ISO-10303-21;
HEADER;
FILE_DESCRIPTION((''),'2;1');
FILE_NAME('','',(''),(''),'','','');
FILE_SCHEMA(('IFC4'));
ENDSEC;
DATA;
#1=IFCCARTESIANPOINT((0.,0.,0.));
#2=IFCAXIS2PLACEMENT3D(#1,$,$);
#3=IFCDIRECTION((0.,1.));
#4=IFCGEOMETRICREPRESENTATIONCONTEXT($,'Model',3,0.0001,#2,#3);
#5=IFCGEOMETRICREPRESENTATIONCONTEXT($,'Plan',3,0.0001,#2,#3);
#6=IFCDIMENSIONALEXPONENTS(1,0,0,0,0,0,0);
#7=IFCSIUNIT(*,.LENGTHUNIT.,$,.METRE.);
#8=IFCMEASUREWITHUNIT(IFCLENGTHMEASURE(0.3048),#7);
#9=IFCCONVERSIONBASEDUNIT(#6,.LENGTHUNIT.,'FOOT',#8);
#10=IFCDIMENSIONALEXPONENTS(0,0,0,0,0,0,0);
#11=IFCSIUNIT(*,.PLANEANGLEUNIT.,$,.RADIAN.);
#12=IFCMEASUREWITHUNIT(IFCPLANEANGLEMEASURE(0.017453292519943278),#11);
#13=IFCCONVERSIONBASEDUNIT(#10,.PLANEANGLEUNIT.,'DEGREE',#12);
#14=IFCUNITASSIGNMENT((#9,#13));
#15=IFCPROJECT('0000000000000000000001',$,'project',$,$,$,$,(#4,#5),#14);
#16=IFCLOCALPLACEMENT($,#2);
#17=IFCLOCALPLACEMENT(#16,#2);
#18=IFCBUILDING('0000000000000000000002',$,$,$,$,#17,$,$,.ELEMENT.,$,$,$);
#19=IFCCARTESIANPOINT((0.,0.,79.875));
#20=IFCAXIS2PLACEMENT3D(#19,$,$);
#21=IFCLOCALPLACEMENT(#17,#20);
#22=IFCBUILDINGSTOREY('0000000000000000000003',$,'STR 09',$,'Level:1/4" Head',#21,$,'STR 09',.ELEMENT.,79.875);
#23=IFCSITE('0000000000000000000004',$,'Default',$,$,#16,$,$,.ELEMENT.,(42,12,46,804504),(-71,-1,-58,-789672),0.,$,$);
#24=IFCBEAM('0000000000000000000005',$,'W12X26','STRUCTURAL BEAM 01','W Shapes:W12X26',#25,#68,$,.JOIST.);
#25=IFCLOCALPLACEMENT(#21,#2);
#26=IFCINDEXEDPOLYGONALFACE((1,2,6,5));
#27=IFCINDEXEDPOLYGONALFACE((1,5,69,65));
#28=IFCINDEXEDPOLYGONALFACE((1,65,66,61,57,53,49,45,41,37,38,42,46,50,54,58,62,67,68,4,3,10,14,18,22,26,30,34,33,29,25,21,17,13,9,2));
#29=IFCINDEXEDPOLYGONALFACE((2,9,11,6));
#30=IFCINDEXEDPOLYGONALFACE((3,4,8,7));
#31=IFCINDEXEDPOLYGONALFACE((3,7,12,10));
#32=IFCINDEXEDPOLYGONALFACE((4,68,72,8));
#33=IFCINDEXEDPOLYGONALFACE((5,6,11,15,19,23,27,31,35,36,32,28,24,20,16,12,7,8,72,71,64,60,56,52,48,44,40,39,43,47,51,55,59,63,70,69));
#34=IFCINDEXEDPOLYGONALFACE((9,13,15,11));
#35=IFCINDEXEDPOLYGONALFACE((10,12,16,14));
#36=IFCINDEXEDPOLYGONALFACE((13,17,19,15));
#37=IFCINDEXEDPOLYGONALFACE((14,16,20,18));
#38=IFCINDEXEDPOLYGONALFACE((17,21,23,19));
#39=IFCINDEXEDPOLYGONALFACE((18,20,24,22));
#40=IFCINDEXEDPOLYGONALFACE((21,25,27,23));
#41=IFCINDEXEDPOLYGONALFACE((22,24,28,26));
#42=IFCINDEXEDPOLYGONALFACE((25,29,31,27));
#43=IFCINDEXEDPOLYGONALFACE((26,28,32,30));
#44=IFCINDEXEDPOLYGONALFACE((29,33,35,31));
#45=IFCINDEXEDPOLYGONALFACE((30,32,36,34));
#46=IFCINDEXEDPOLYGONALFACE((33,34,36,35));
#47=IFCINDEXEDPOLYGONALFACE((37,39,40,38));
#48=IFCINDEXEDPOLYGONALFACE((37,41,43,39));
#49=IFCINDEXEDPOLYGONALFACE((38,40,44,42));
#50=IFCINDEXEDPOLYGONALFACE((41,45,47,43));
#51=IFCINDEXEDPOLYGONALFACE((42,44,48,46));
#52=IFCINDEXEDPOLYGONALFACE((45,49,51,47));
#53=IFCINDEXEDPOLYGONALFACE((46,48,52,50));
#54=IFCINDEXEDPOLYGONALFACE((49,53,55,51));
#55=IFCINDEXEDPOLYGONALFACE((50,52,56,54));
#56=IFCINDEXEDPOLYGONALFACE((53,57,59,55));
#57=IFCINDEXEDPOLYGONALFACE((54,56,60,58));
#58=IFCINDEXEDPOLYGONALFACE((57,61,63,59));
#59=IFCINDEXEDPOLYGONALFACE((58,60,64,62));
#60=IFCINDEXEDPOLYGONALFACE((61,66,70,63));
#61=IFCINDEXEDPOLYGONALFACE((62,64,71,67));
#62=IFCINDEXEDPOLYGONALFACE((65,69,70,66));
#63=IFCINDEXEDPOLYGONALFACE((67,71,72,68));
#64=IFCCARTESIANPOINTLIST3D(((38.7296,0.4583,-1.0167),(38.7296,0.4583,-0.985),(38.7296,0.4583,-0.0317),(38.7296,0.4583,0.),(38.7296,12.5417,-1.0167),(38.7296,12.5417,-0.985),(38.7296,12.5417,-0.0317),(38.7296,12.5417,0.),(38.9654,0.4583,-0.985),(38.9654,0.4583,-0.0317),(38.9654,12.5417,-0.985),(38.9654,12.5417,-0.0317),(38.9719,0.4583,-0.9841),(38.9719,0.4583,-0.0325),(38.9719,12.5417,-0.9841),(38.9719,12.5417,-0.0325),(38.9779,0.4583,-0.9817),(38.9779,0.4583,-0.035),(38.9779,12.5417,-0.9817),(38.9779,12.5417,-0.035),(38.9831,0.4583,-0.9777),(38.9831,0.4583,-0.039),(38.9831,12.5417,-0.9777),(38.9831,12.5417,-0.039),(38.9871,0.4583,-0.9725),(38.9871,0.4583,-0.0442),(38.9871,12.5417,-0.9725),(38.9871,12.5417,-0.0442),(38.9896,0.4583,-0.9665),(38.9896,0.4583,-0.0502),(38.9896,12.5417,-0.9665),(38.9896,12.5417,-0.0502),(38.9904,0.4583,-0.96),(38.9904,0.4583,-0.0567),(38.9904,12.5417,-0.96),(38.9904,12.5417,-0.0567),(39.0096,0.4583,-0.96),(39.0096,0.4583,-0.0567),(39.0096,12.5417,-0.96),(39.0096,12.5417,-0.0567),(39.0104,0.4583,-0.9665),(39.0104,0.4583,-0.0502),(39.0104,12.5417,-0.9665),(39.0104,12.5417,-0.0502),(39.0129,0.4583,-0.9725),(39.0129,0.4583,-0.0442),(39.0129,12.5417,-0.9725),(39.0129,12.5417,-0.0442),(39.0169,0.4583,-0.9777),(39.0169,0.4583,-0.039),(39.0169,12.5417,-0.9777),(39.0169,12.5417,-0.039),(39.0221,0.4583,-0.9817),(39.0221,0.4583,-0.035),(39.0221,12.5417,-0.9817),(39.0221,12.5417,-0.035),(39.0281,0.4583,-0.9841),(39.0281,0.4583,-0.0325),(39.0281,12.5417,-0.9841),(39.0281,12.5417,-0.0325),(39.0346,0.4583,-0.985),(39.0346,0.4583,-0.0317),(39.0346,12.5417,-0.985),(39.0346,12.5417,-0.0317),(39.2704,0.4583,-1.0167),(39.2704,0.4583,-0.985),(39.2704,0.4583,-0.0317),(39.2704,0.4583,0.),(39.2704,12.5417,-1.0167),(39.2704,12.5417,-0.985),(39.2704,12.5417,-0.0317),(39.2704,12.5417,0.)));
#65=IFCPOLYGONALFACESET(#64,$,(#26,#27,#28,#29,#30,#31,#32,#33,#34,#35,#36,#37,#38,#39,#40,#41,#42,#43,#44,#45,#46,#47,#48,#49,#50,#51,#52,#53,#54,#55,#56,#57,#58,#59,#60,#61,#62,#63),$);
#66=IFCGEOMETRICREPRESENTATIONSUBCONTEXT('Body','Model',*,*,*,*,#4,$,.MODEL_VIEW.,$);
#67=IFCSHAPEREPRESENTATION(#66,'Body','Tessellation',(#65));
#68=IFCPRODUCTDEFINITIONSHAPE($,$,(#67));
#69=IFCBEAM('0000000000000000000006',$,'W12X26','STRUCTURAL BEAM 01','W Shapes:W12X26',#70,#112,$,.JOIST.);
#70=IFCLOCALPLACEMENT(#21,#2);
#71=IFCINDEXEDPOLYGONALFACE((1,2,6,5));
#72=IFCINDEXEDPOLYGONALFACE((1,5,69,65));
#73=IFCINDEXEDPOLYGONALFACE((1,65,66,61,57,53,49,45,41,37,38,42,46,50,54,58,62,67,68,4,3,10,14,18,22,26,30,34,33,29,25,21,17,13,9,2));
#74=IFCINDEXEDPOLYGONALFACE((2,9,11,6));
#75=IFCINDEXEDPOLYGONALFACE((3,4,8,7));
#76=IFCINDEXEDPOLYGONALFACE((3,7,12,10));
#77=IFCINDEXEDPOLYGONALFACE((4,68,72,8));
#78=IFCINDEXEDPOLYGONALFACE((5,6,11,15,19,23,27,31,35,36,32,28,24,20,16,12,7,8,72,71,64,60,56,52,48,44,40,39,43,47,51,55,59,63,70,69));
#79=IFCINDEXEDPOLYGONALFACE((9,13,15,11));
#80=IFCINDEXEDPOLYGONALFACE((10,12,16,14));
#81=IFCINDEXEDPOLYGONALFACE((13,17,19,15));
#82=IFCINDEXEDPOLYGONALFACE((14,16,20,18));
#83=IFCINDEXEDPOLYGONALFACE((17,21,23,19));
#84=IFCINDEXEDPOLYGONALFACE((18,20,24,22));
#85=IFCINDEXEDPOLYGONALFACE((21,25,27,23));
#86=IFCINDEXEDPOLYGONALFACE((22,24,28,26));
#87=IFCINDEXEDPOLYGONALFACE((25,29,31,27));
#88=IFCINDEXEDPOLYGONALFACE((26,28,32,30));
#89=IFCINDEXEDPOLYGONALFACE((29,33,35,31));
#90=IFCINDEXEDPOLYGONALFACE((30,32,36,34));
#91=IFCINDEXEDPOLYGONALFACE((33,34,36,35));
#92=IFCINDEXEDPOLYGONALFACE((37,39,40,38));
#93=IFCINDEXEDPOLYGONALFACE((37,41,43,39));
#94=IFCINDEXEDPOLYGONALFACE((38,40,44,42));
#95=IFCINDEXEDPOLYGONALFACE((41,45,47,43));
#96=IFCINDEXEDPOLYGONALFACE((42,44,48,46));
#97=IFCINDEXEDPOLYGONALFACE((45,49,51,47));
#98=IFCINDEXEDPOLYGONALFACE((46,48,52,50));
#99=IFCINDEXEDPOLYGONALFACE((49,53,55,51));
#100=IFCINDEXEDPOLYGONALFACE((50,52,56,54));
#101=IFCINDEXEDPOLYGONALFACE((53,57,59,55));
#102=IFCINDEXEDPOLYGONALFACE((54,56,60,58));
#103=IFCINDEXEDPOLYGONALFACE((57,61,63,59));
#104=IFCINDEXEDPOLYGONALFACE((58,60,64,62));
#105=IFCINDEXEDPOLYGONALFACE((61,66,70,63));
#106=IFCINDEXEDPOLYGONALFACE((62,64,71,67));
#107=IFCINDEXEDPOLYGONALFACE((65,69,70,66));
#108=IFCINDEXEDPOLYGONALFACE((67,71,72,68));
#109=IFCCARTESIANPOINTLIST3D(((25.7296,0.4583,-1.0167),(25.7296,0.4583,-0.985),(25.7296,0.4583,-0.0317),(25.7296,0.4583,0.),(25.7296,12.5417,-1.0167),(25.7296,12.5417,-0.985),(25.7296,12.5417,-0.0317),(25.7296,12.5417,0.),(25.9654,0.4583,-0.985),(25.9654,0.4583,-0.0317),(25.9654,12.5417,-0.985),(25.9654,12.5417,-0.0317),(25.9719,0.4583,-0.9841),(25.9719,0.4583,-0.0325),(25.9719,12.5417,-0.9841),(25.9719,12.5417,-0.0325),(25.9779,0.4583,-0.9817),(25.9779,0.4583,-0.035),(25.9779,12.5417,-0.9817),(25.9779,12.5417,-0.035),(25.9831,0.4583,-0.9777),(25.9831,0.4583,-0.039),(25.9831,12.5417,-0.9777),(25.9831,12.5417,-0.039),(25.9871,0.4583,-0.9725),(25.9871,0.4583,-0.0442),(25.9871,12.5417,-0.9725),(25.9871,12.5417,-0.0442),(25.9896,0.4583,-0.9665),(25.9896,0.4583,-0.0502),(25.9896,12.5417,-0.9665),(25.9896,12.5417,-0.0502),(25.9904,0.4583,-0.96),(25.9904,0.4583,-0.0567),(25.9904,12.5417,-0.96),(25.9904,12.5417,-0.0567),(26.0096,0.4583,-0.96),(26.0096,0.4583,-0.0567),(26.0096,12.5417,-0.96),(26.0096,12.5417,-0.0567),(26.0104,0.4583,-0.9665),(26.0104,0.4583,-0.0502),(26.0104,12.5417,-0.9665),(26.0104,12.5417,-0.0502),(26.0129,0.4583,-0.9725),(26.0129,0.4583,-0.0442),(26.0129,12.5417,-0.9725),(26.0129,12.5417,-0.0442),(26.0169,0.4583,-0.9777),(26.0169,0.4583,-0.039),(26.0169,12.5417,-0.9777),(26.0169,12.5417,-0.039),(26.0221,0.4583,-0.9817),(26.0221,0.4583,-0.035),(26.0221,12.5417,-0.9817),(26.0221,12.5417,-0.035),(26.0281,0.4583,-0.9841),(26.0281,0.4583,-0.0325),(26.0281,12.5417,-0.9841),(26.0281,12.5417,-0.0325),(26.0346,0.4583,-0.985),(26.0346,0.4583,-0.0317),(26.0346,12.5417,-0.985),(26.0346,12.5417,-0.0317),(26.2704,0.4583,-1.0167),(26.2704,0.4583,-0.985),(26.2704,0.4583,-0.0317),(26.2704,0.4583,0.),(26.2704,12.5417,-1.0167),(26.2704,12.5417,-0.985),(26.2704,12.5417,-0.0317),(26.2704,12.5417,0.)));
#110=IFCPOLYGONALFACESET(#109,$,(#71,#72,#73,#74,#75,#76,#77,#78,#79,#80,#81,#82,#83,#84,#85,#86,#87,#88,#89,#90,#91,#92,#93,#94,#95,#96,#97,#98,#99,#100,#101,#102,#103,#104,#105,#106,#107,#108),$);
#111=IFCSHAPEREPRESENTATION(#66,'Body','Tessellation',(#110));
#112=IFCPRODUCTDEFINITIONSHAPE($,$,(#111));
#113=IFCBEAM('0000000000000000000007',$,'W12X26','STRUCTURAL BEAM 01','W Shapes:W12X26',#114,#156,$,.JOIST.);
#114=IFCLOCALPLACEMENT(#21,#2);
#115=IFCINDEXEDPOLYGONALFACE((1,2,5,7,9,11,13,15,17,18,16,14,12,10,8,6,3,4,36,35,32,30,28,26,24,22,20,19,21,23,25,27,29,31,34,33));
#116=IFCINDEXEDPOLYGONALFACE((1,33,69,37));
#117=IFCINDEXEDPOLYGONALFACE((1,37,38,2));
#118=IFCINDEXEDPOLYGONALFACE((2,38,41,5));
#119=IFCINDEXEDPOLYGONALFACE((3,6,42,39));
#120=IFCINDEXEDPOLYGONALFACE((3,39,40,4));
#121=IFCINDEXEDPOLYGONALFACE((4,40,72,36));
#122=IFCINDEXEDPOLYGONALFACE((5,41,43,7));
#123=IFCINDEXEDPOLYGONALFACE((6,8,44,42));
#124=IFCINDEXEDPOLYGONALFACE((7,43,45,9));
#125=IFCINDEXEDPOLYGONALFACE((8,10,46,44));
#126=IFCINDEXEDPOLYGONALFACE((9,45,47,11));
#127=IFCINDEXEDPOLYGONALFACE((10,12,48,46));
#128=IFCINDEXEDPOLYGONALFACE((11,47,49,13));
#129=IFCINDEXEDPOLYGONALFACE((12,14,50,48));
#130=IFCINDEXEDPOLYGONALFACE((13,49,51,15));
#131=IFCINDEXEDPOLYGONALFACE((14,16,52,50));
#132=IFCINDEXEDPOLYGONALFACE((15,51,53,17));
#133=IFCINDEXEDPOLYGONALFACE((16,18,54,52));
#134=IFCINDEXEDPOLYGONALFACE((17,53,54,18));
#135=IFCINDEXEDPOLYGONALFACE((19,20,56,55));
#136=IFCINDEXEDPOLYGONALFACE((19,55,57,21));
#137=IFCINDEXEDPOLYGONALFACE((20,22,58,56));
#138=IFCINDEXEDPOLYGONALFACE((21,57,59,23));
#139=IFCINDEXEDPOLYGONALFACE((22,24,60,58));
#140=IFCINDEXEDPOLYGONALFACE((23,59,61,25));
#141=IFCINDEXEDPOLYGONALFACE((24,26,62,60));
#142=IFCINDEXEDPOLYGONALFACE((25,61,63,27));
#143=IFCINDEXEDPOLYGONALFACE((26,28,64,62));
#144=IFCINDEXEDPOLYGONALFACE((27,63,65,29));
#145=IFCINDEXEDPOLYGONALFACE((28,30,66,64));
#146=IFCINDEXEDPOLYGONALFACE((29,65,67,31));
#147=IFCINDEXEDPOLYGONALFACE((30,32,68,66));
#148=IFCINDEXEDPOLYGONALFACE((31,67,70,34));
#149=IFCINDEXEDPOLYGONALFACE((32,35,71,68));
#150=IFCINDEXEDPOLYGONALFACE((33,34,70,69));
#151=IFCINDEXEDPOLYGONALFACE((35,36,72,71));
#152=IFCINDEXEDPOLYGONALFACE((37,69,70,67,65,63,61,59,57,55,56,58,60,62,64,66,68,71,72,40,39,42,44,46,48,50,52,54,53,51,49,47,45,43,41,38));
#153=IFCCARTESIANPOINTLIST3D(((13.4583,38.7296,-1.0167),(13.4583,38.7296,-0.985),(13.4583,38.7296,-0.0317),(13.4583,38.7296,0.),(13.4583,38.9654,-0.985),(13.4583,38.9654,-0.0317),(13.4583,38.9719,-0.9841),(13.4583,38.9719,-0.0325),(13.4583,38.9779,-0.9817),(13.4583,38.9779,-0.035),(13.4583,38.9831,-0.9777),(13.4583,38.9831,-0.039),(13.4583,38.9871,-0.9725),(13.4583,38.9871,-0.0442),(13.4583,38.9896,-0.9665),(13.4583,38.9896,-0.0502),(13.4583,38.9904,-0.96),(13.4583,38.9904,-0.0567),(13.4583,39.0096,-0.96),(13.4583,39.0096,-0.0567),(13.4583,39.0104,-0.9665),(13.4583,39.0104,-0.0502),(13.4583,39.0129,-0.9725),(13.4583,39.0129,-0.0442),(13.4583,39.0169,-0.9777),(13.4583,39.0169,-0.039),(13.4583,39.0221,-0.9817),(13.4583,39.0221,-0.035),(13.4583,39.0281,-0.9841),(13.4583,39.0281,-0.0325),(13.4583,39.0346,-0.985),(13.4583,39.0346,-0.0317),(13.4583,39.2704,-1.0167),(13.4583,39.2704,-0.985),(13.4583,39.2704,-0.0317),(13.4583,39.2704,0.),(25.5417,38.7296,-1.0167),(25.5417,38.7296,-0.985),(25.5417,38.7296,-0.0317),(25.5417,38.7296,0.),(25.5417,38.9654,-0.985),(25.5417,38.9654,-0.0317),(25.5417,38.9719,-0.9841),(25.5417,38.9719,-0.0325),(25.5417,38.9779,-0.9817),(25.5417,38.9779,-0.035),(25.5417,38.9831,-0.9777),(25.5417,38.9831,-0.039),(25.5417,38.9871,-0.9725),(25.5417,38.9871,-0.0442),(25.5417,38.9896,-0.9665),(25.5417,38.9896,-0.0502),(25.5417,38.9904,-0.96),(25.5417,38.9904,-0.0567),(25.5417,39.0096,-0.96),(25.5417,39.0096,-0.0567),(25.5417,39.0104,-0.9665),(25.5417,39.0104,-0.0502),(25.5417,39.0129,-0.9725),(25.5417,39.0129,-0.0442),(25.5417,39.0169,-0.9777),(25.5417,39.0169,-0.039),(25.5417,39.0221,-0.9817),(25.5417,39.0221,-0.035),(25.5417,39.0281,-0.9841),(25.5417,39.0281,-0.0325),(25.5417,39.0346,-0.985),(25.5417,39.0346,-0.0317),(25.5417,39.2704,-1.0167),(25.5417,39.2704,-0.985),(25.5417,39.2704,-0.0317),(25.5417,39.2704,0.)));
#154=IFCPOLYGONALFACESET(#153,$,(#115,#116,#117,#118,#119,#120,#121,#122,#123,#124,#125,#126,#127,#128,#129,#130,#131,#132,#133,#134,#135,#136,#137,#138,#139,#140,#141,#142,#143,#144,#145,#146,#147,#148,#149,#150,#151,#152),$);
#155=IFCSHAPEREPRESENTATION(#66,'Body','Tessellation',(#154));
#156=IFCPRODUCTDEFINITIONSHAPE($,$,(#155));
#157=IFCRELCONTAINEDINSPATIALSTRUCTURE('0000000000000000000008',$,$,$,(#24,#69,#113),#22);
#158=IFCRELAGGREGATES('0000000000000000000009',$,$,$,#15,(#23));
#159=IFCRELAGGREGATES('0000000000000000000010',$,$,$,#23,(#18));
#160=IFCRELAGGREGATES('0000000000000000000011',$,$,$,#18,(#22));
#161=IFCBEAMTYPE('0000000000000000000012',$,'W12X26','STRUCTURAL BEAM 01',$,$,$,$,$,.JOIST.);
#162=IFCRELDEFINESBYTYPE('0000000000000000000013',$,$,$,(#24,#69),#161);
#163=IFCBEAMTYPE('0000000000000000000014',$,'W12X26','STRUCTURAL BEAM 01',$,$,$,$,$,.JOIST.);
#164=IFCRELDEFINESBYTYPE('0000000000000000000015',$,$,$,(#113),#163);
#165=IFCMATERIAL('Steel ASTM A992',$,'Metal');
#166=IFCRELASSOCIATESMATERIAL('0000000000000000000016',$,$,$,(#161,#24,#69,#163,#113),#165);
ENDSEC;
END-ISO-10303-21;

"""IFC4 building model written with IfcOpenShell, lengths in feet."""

from ifc_helpers import new_model, entity, si_unit, converted_unit, direction, frame, origin, place, context, subcontext, project, spatial, line, arc, indexed_curve, outline, extrude, source, transform, mapped, material, type_object, type_shapes, element, save


model = new_model("IFC4")

# Units and contexts
model_context = context("Model", 3, precision=0.0001, world=origin(), true_north=direction((0.0, 1.0)))
plan_context = context("Plan", 3, precision=0.0001, world=origin(), true_north=direction((0.0, 1.0)))
body_context = subcontext(model_context, "Body", "Model", "MODEL_VIEW")
ifc_project = project(units=[converted_unit("LENGTHUNIT", "FOOT", entity("IfcLengthMeasure", 0.3048), si_unit("LENGTHUNIT", "METRE"), dimensions=[1, 0, 0, 0, 0, 0, 0]), converted_unit("PLANEANGLEUNIT", "DEGREE", entity("IfcPlaneAngleMeasure", 0.017453292519943278), si_unit("PLANEANGLEUNIT", "RADIAN"), dimensions=[0, 0, 0, 0, 0, 0, 0])], contexts=[model_context, plan_context])

# Site, building, storey
site_placement = place(None, origin())
site = spatial("IfcSite", under=ifc_project, at=site_placement, Name="Default", CompositionType="ELEMENT", RefLatitude=(42, 12, 46, 804504), RefLongitude=(-71, -1, -58, -789672), RefElevation=0.0)
building_placement = place(site_placement, origin())
building = spatial("IfcBuilding", under=site, at=building_placement, CompositionType="ELEMENT")
storey_placement = place(building_placement, frame((0.0, 0.0, 79.875)))
storey = spatial("IfcBuildingStorey", under=building, at=storey_placement, Name="STR 09", ObjectType="Level:1/4\" Head", LongName="STR 09", CompositionType="ELEMENT", Elevation=79.875)

# Beams
ifc_material = material(Name="Steel ASTM A992", Category="Metal")
beam_type_1 = type_object("IfcBeamType", Name="W12X26", Description="STRUCTURAL BEAM 01", PredefinedType="JOIST", material=ifc_material)
shared_shape_1 = source(origin(), body_context, "Body", "SweptSolid", [
    extrude(outline(indexed_curve([(-0.2704, -0.4767), (-0.2704, -0.5083), (0.2704, -0.5083), (0.2704, -0.4767), (0.0346, -0.4767), (0.0169, -0.4693), (0.0096, -0.4517), (0.0096, 0.4517), (0.0169, 0.4693), (0.0346, 0.4767), (0.2704, 0.4767), (0.2704, 0.5083), (-0.2704, 0.5083), (-0.2704, 0.4767), (-0.0346, 0.4767), (-0.0169, 0.4693), (-0.0096, 0.4517), (-0.0096, -0.4517), (-0.0169, -0.4693), (-0.0346, -0.4767)], segments=[line(1, 2, 3, 4, 5), arc(5, 6, 7), line(7, 8), arc(8, 9, 10), line(10, 11, 12, 13, 14, 15), arc(15, 16, 17), line(17, 18), arc(18, 19, 20), line(20, 1)], self_intersect=False)), frame((-6.1033, 0.0, 0.0), z_axis=(-1.0, 0.0, 0.0), x_axis=(0.0, -1.0, 0.0)), (0.0, 0.0, -1.0), 12.0833),
])
type_shapes(beam_type_1, [shared_shape_1])
for number, where, z_axis, x_axis, name in (
    (1, (39.0, 6.5617, -0.5083), (0.0, 0.0, 1.0), (0.0, 1.0, 0.0), "W12X26"),
    (2, (26.0, 6.5617, -0.5083), (0.0, 0.0, 1.0), (0.0, 1.0, 0.0), "W12X26"),
):
    element("IfcBeam", number, at=place(storey_placement, frame(where, z_axis=z_axis, x_axis=x_axis)), inside=storey, type_object=beam_type_1, material=ifc_material, Name=name, Description="STRUCTURAL BEAM 01", ObjectType="W Shapes:W12X26", PredefinedType="JOIST", context=body_context, shape_type="MappedRepresentation", body=[
        mapped(shared_shape_1, transform((0.0, 0.0, 0.0), scale=1.0)),
    ])
beam_type_2 = type_object("IfcBeamType", Name="W12X26", Description="STRUCTURAL BEAM 01", PredefinedType="JOIST", material=ifc_material)
shared_shape_2 = source(origin(), body_context, "Body", "SweptSolid", [
    extrude(outline(indexed_curve([(-0.2704, -0.4767), (-0.2704, -0.5083), (0.2704, -0.5083), (0.2704, -0.4767), (0.0346, -0.4767), (0.0169, -0.4693), (0.0096, -0.4517), (0.0096, 0.4517), (0.0169, 0.4693), (0.0346, 0.4767), (0.2704, 0.4767), (0.2704, 0.5083), (-0.2704, 0.5083), (-0.2704, 0.4767), (-0.0346, 0.4767), (-0.0169, 0.4693), (-0.0096, 0.4517), (-0.0096, -0.4517), (-0.0169, -0.4693), (-0.0346, -0.4767)], segments=[line(1, 2, 3, 4, 5), arc(5, 6, 7), line(7, 8), arc(8, 9, 10), line(10, 11, 12, 13, 14, 15), arc(15, 16, 17), line(17, 18), arc(18, 19, 20), line(20, 1)], self_intersect=False)), frame((-6.2267, 0.0, 0.0), z_axis=(-1.0, 0.0, 0.0), x_axis=(0.0, -1.0, 0.0)), (0.0, 0.0, -1.0), 12.0833),
])
type_shapes(beam_type_2, [shared_shape_2])
beam_1_placement = place(storey_placement, frame((19.685, 39.0, -0.5083)))
element("IfcBeam", 3, at=beam_1_placement, inside=storey, type_object=beam_type_2, material=ifc_material, Name="W12X26", Description="STRUCTURAL BEAM 01", ObjectType="W Shapes:W12X26", PredefinedType="JOIST", context=body_context, shape_type="MappedRepresentation", body=[
    mapped(shared_shape_2, transform((0.0, 0.0, 0.0), scale=1.0)),
])

save(model, "model.ifc")
